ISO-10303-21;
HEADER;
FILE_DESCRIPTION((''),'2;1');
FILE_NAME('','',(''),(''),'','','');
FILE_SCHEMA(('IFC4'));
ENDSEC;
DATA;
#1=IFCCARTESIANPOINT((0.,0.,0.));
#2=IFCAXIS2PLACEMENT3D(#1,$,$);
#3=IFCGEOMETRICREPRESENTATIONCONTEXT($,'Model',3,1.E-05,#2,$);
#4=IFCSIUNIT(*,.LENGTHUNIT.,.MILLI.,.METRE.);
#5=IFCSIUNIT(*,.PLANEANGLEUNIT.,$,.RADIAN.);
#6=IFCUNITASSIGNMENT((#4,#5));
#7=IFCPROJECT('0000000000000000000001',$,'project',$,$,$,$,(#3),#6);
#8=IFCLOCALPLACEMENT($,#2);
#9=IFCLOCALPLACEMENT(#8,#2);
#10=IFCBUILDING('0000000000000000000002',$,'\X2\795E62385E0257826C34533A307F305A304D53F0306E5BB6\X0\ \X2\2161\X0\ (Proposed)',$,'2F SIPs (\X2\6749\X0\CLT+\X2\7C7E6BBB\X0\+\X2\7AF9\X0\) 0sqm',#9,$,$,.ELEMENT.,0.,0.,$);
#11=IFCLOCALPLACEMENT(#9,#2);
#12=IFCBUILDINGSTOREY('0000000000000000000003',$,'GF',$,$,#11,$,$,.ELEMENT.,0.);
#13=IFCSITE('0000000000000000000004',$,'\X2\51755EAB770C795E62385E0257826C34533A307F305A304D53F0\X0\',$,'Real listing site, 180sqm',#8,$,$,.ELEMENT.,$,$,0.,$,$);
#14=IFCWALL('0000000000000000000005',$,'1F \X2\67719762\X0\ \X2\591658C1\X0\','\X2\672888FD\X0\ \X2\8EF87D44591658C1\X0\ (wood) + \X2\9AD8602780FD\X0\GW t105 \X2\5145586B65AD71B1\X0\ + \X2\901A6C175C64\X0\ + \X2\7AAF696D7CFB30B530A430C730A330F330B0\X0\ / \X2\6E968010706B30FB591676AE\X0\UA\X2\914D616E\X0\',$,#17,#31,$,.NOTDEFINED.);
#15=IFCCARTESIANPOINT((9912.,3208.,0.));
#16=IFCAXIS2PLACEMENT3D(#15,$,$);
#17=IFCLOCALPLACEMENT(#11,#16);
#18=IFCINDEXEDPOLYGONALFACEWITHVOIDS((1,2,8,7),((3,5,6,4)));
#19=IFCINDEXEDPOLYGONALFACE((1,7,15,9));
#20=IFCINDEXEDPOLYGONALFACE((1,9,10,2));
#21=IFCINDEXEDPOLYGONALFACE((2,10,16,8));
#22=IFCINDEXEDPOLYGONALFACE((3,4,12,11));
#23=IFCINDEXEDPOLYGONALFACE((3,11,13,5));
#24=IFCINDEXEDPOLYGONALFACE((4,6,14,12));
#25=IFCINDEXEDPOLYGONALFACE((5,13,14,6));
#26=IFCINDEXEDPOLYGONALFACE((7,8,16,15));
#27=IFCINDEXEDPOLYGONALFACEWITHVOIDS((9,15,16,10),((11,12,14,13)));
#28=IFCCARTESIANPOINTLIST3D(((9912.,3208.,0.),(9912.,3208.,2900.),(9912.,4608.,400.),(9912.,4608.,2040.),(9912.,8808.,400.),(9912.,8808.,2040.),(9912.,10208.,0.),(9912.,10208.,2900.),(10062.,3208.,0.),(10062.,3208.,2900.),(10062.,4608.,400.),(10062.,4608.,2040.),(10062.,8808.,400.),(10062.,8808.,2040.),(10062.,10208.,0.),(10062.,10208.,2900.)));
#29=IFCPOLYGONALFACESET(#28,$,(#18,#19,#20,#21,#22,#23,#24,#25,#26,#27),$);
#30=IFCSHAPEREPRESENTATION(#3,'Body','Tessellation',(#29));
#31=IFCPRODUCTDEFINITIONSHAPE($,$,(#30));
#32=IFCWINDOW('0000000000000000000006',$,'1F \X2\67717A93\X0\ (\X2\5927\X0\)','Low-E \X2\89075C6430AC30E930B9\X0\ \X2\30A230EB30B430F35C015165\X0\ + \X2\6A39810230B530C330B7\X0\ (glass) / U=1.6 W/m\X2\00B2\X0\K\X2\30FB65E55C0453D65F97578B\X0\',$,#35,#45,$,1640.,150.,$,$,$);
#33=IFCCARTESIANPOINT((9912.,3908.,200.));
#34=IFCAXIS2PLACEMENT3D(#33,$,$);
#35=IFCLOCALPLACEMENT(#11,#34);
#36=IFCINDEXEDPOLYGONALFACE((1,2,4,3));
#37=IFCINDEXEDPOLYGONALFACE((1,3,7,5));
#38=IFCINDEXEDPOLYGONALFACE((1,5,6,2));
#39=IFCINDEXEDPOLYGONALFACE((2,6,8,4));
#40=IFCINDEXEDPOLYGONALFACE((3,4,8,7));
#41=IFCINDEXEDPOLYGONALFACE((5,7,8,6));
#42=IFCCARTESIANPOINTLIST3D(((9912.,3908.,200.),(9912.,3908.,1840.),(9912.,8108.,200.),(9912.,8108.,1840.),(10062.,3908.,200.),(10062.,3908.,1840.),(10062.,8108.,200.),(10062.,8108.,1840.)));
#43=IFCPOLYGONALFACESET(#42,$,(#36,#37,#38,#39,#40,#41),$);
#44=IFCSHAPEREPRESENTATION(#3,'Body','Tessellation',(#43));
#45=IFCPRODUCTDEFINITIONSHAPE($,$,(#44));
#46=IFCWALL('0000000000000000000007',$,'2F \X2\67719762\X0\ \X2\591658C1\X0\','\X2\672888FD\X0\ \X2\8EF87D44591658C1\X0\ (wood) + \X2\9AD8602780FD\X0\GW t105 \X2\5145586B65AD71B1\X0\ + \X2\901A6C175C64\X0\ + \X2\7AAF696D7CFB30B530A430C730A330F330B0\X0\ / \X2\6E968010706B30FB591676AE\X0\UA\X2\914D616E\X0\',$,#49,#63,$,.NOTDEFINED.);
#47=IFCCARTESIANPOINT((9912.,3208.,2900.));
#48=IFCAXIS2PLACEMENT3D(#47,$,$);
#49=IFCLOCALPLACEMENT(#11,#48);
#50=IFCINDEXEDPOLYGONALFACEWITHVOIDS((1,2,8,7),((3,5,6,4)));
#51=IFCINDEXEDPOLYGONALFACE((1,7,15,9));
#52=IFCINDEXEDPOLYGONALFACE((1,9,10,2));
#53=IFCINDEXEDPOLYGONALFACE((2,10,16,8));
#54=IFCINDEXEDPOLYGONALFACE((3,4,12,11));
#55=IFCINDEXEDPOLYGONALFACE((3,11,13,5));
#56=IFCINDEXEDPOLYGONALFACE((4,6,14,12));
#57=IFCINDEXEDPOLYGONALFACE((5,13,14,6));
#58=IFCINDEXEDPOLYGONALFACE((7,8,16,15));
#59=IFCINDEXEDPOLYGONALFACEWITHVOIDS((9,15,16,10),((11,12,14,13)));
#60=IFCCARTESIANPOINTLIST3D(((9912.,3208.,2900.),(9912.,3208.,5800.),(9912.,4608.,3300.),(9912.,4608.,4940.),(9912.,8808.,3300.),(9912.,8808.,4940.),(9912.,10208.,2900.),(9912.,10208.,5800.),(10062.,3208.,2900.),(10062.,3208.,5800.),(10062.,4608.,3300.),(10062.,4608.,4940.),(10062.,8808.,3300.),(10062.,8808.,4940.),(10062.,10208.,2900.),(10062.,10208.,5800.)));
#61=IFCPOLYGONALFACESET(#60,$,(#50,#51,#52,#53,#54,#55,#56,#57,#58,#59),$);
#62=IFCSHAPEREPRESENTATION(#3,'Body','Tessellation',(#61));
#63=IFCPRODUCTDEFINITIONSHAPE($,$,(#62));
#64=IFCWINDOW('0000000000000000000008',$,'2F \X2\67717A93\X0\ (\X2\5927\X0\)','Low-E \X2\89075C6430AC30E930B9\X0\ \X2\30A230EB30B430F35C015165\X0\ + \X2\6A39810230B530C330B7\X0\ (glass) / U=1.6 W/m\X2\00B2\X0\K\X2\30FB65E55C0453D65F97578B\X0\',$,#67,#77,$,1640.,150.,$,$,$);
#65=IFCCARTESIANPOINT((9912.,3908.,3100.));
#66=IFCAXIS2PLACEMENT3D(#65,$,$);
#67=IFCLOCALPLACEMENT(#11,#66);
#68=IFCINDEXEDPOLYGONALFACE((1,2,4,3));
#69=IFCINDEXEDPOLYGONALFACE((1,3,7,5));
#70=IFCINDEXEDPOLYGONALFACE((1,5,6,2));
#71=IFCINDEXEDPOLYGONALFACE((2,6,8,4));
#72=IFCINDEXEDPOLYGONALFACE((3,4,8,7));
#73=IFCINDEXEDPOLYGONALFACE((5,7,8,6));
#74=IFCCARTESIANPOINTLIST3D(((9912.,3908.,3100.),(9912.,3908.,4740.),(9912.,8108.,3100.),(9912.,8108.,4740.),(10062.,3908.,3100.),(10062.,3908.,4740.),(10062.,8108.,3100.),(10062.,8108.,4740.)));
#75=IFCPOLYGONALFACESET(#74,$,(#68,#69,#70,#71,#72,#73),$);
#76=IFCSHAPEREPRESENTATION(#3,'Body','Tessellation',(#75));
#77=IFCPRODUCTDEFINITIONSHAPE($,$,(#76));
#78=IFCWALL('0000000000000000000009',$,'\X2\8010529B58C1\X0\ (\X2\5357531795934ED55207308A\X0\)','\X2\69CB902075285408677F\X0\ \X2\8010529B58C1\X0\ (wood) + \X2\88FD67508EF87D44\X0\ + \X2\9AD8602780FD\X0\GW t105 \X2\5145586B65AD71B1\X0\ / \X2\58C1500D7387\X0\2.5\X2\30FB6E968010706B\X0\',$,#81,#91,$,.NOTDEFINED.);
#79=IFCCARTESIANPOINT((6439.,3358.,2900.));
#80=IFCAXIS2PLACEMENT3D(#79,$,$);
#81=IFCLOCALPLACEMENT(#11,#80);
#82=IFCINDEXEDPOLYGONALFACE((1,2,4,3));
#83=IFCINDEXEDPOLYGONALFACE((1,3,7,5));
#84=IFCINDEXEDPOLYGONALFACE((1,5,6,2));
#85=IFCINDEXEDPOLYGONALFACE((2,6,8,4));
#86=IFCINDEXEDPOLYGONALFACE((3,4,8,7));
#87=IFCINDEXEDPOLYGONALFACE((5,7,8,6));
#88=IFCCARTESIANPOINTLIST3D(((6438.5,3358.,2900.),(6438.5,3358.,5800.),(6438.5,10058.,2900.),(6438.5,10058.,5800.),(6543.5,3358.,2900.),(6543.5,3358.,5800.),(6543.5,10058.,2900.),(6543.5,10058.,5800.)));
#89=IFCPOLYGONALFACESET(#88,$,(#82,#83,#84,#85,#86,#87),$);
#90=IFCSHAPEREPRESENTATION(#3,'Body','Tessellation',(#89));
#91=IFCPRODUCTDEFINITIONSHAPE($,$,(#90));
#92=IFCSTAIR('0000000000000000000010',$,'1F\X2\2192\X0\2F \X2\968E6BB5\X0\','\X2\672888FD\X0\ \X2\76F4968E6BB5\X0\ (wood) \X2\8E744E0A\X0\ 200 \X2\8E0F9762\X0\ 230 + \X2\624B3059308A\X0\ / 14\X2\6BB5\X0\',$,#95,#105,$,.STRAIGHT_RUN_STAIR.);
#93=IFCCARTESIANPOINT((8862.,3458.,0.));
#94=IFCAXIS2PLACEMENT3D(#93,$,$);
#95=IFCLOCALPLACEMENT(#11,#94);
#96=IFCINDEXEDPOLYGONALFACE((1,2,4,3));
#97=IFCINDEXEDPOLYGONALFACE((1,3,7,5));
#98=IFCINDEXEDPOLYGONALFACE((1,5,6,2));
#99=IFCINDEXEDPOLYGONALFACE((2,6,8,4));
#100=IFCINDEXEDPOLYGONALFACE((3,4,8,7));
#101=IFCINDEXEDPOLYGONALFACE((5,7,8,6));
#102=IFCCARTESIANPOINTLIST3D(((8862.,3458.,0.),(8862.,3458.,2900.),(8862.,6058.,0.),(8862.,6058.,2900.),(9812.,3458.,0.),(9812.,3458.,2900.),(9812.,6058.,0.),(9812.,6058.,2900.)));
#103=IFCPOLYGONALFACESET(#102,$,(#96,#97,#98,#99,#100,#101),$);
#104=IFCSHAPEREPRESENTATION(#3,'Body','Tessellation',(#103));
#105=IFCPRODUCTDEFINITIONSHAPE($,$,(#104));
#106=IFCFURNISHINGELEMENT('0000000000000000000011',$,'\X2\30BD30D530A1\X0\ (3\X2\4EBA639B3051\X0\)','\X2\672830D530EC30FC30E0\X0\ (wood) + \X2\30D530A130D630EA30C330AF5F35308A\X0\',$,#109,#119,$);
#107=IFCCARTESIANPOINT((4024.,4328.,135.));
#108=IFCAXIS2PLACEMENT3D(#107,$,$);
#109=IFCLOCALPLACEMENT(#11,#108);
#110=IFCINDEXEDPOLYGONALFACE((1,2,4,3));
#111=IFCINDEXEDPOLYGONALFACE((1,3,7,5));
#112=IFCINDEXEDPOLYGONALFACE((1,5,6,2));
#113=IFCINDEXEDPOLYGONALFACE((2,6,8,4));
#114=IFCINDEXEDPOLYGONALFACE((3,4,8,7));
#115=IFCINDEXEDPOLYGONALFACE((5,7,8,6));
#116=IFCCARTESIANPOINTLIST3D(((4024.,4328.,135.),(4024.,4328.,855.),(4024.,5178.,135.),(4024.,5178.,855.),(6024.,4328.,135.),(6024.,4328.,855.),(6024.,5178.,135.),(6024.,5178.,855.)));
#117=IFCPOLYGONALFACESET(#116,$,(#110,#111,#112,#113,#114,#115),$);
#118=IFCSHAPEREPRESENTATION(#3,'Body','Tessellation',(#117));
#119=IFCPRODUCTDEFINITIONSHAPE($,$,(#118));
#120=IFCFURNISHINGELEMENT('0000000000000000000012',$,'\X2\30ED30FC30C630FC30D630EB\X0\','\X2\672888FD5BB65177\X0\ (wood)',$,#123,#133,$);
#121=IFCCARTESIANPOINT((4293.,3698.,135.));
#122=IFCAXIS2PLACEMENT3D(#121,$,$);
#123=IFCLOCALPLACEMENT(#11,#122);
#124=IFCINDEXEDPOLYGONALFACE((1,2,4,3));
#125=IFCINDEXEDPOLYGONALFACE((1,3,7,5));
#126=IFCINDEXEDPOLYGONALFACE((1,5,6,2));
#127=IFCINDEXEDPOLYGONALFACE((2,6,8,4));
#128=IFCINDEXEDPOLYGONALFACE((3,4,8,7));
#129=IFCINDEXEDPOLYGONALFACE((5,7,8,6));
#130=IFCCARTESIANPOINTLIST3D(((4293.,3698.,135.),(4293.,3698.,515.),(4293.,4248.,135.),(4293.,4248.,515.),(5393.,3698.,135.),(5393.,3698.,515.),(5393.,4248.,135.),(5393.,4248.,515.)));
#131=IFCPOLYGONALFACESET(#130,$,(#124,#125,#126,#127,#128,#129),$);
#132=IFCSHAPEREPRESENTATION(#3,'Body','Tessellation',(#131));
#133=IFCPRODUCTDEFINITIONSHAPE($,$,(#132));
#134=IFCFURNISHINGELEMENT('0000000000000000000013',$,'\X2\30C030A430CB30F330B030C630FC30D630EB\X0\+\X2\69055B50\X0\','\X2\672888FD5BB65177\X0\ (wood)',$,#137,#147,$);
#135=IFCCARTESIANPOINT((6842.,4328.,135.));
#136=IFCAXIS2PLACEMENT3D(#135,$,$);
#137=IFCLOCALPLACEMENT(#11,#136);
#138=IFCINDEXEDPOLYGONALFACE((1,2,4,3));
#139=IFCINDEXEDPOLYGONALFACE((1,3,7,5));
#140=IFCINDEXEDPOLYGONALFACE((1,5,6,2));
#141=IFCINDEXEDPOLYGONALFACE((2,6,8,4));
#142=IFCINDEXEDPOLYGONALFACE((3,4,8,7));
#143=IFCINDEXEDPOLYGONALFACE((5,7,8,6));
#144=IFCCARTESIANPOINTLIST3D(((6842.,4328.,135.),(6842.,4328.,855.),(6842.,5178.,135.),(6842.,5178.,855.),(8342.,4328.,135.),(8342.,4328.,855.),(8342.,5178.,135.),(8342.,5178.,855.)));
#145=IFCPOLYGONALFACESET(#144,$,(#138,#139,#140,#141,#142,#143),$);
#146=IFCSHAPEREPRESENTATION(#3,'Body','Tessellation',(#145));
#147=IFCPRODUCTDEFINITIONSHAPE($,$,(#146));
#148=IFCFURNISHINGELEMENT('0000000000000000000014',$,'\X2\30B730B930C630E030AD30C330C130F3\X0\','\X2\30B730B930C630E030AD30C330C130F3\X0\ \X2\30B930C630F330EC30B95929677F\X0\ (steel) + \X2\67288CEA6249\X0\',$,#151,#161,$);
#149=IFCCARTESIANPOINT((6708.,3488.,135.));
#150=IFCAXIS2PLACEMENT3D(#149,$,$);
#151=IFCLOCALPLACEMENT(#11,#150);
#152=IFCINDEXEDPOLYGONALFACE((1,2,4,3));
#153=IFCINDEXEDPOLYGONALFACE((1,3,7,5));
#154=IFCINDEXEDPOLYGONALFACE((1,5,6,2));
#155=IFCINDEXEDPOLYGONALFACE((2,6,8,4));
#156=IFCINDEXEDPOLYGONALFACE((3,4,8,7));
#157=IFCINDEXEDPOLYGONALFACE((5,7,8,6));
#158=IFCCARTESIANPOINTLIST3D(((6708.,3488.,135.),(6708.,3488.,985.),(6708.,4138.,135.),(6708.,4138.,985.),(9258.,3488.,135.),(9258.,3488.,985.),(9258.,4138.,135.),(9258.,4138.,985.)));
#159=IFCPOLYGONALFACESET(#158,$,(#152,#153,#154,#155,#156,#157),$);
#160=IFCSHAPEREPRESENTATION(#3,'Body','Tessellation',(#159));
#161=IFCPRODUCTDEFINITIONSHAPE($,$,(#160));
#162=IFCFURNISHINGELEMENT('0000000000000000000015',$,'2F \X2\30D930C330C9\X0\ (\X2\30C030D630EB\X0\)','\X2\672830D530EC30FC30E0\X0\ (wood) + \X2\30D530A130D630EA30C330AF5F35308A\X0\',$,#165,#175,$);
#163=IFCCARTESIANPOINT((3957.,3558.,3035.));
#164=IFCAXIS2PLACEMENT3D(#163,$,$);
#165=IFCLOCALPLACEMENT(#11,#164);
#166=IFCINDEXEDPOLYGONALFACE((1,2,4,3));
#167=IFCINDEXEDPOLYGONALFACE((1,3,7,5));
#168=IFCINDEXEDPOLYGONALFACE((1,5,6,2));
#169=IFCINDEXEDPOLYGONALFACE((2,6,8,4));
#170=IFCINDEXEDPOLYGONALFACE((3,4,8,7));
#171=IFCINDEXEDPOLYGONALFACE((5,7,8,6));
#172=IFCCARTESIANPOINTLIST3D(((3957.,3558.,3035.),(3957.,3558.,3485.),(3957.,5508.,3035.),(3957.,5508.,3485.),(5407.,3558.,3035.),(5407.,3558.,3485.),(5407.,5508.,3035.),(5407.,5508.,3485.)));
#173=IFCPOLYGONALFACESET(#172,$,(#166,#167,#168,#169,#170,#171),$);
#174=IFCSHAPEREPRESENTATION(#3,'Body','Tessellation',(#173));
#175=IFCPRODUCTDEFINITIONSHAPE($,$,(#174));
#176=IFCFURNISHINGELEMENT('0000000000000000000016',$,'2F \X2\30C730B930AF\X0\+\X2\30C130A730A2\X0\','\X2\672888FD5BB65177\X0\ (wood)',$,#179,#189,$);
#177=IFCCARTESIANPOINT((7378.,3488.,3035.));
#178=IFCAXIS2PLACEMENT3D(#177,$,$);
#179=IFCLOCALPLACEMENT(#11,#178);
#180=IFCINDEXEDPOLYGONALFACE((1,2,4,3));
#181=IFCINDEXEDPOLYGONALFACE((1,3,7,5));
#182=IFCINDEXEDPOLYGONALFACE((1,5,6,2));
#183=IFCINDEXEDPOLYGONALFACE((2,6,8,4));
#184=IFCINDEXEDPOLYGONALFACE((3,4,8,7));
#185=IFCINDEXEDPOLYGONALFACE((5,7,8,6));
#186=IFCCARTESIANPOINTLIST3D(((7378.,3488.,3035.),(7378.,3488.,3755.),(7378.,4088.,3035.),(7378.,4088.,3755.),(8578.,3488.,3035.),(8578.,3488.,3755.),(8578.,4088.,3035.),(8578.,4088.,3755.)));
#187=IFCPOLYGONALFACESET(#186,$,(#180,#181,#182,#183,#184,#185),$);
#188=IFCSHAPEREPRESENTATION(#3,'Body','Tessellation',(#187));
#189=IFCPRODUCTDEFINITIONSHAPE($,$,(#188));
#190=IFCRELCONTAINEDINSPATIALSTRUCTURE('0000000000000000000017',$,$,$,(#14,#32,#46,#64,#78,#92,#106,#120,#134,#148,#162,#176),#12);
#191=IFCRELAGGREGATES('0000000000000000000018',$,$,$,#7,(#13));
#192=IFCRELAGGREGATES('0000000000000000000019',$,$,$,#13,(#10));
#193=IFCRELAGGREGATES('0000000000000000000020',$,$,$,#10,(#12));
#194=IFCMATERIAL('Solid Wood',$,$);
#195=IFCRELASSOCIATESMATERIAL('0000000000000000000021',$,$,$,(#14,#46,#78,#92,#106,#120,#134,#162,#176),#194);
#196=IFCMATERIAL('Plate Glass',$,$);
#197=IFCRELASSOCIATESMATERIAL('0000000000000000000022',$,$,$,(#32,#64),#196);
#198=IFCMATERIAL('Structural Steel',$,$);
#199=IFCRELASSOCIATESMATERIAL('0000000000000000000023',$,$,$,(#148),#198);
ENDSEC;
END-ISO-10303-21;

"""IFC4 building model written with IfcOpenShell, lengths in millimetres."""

from ifc_helpers import new_model, si_unit, frame, frame_2d, origin, place, context, project, spatial, rectangle, extrude, material, element, fill, save


model = new_model("IFC4")

# Units and contexts
model_context = context("Model", 3, precision=1e-05, world=origin())
ifc_project = project(units=[si_unit("LENGTHUNIT", "METRE", prefix="MILLI"), si_unit("PLANEANGLEUNIT", "RADIAN")], contexts=[model_context])

# Site, building, storey
site_placement = place(None, origin())
site = spatial("IfcSite", under=ifc_project, at=site_placement, Name="兵庫県神戸市垂水区みずき台", ObjectType="Real listing site, 180sqm", CompositionType="ELEMENT", RefElevation=0.0)
building_placement = place(site_placement, origin())
building = spatial("IfcBuilding", under=site, at=building_placement, Name="神戸市垂水区みずき台の家 Ⅱ (Proposed)", ObjectType="2F SIPs (杉CLT+籾殻+竹) 0sqm", CompositionType="ELEMENT", ElevationOfRefHeight=0.0, ElevationOfTerrain=0.0)
storey_placement = place(building_placement, origin())
storey = spatial("IfcBuildingStorey", under=building, at=storey_placement, Name="GF", CompositionType="ELEMENT", Elevation=0.0)

# Wall, opening, window
ifc_material_1 = material(Name="Solid Wood")
wall_1_placement = place(storey_placement, frame((9912.0, 3208.0, 0.0)))
wall_1 = element("IfcWall", 1, at=wall_1_placement, inside=storey, material=ifc_material_1, Name="1F 東面 外壁", Description="木製 軸組外壁 (wood) + 高性能GW t105 充填断熱 + 通気層 + 窯業系サイディング / 準耐火・外皮UA配慮", PredefinedType="NOTDEFINED", context=model_context, shape_type="SweptSolid", body=[
    extrude(rectangle(XDim=150.0, YDim=7000.0, at=frame_2d((75.0, 3500.0))), frame((9912.0, 3208.0, 0.0)), (0.0, 0.0, 1.0), 2900.0),
])
opening_1_placement = place(storey_placement, frame((9912.0, 3908.0, 200.0)))
opening_1 = element("IfcOpeningElement", 2, at=opening_1_placement, cuts=wall_1, PredefinedType="NOTDEFINED", context=model_context, shape_type="SweptSolid", body=[
    extrude(rectangle(XDim=150.0, YDim=4200.0, at=frame_2d((75.0, 2100.0))), frame((9912.0, 3908.0, 200.0)), (0.0, 0.0, 1.0), 1640.0),
])
ifc_material_2 = material(Name="Plate Glass")
window_1_placement = place(storey_placement, frame((9912.0, 3908.0, 200.0)))
window_1 = element("IfcWindow", 3, at=window_1_placement, inside=storey, material=ifc_material_2, Name="1F 東窓 (大)", Description="Low-E 複層ガラス アルゴン封入 + 樹脂サッシ (glass) / U=1.6 W/m²K・日射取得型", OverallHeight=1640.0, OverallWidth=150.0, context=model_context, shape_type="SweptSolid", body=[
    extrude(rectangle(XDim=150.0, YDim=4200.0, at=frame_2d((75.0, 2100.0))), frame((9912.0, 3908.0, 200.0)), (0.0, 0.0, 1.0), 1640.0),
])
fill(opening_1, window_1)

# Wall, opening, window
wall_2_placement = place(storey_placement, frame((9912.0, 3208.0, 2900.0)))
wall_2 = element("IfcWall", 4, at=wall_2_placement, inside=storey, material=ifc_material_1, Name="2F 東面 外壁", Description="木製 軸組外壁 (wood) + 高性能GW t105 充填断熱 + 通気層 + 窯業系サイディング / 準耐火・外皮UA配慮", PredefinedType="NOTDEFINED", context=model_context, shape_type="SweptSolid", body=[
    extrude(rectangle(XDim=150.0, YDim=7000.0, at=frame_2d((75.0, 3500.0))), frame((9912.0, 3208.0, 2900.0)), (0.0, 0.0, 1.0), 2900.0),
])
opening_2_placement = place(storey_placement, frame((9912.0, 3908.0, 3100.0)))
opening_2 = element("IfcOpeningElement", 5, at=opening_2_placement, cuts=wall_2, PredefinedType="NOTDEFINED", context=model_context, shape_type="SweptSolid", body=[
    extrude(rectangle(XDim=150.0, YDim=4200.0, at=frame_2d((75.0, 2100.0))), frame((9912.0, 3908.0, 3100.0)), (0.0, 0.0, 1.0), 1640.0),
])
window_2_placement = place(storey_placement, frame((9912.0, 3908.0, 3100.0)))
window_2 = element("IfcWindow", 6, at=window_2_placement, inside=storey, material=ifc_material_2, Name="2F 東窓 (大)", Description="Low-E 複層ガラス アルゴン封入 + 樹脂サッシ (glass) / U=1.6 W/m²K・日射取得型", OverallHeight=1640.0, OverallWidth=150.0, context=model_context, shape_type="SweptSolid", body=[
    extrude(rectangle(XDim=150.0, YDim=4200.0, at=frame_2d((75.0, 2100.0))), frame((9912.0, 3908.0, 3100.0)), (0.0, 0.0, 1.0), 1640.0),
])
fill(opening_2, window_2)

# Wall
wall_3_placement = place(storey_placement, frame((6439.0, 3358.0, 2900.0)))
element("IfcWall", 7, at=wall_3_placement, inside=storey, material=ifc_material_1, Name="耐力壁 (南北間仕切り)", Description="構造用合板 耐力壁 (wood) + 製材軸組 + 高性能GW t105 充填断熱 / 壁倍率2.5・準耐火", PredefinedType="NOTDEFINED", context=model_context, shape_type="SweptSolid", body=[
    extrude(rectangle(XDim=105.0, YDim=6700.0, at=frame_2d((52.0, 3350.0))), frame((6439.0, 3358.0, 2900.0)), (0.0, 0.0, 1.0), 2900.0),
])

# Stair
stair_placement = place(storey_placement, frame((8862.0, 3458.0, 0.0)))
element("IfcStair", 8, at=stair_placement, inside=storey, material=ifc_material_1, Name="1F→2F 階段", Description="木製 直階段 (wood) 蹴上 200 踏面 230 + 手すり / 14段", PredefinedType="STRAIGHT_RUN_STAIR", context=model_context, shape_type="SweptSolid", body=[
    extrude(rectangle(XDim=950.0, YDim=2600.0, at=frame_2d((475.0, 1300.0))), frame((8862.0, 3458.0, 0.0)), (0.0, 0.0, 1.0), 2900.0),
])

# Furnishing elements
furnishing_1_placement = place(storey_placement, frame((4024.0, 4328.0, 135.0)))
element("IfcFurnishingElement", 9, at=furnishing_1_placement, inside=storey, material=ifc_material_1, Name="ソファ (3人掛け)", Description="木フレーム (wood) + ファブリック張り", context=model_context, shape_type="SweptSolid", body=[
    extrude(rectangle(XDim=2000.0, YDim=850.0, at=frame_2d((1000.0, 425.0))), frame((4024.0, 4328.0, 135.0)), (0.0, 0.0, 1.0), 720.0),
])
furnishing_2_placement = place(storey_placement, frame((4293.0, 3698.0, 135.0)))
element("IfcFurnishingElement", 10, at=furnishing_2_placement, inside=storey, material=ifc_material_1, Name="ローテーブル", Description="木製家具 (wood)", context=model_context, shape_type="SweptSolid", body=[
    extrude(rectangle(XDim=1100.0, YDim=550.0, at=frame_2d((550.0, 275.0))), frame((4293.0, 3698.0, 135.0)), (0.0, 0.0, 1.0), 380.0),
])
furnishing_3_placement = place(storey_placement, frame((6842.0, 4328.0, 135.0)))
element("IfcFurnishingElement", 11, at=furnishing_3_placement, inside=storey, material=ifc_material_1, Name="ダイニングテーブル+椅子", Description="木製家具 (wood)", context=model_context, shape_type="SweptSolid", body=[
    extrude(rectangle(XDim=1500.0, YDim=850.0, at=frame_2d((750.0, 425.0))), frame((6842.0, 4328.0, 135.0)), (0.0, 0.0, 1.0), 720.0),
])
ifc_material_3 = material(Name="Structural Steel")
furnishing_4_placement = place(storey_placement, frame((6708.0, 3488.0, 135.0)))
element("IfcFurnishingElement", 12, at=furnishing_4_placement, inside=storey, material=ifc_material_3, Name="システムキッチン", Description="システムキッチン ステンレス天板 (steel) + 木質扉", context=model_context, shape_type="SweptSolid", body=[
    extrude(rectangle(XDim=2550.0, YDim=650.0, at=frame_2d((1275.0, 325.0))), frame((6708.0, 3488.0, 135.0)), (0.0, 0.0, 1.0), 850.0),
])
furnishing_5_placement = place(storey_placement, frame((3957.0, 3558.0, 3035.0)))
element("IfcFurnishingElement", 13, at=furnishing_5_placement, inside=storey, material=ifc_material_1, Name="2F ベッド (ダブル)", Description="木フレーム (wood) + ファブリック張り", context=model_context, shape_type="SweptSolid", body=[
    extrude(rectangle(XDim=1450.0, YDim=1950.0, at=frame_2d((725.0, 975.0))), frame((3957.0, 3558.0, 3035.0)), (0.0, 0.0, 1.0), 450.0),
])
furnishing_6_placement = place(storey_placement, frame((7378.0, 3488.0, 3035.0)))
element("IfcFurnishingElement", 14, at=furnishing_6_placement, inside=storey, material=ifc_material_1, Name="2F デスク+チェア", Description="木製家具 (wood)", context=model_context, shape_type="SweptSolid", body=[
    extrude(rectangle(XDim=1200.0, YDim=600.0, at=frame_2d((600.0, 300.0))), frame((7378.0, 3488.0, 3035.0)), (0.0, 0.0, 1.0), 720.0),
])

save(model, "model.ifc")
